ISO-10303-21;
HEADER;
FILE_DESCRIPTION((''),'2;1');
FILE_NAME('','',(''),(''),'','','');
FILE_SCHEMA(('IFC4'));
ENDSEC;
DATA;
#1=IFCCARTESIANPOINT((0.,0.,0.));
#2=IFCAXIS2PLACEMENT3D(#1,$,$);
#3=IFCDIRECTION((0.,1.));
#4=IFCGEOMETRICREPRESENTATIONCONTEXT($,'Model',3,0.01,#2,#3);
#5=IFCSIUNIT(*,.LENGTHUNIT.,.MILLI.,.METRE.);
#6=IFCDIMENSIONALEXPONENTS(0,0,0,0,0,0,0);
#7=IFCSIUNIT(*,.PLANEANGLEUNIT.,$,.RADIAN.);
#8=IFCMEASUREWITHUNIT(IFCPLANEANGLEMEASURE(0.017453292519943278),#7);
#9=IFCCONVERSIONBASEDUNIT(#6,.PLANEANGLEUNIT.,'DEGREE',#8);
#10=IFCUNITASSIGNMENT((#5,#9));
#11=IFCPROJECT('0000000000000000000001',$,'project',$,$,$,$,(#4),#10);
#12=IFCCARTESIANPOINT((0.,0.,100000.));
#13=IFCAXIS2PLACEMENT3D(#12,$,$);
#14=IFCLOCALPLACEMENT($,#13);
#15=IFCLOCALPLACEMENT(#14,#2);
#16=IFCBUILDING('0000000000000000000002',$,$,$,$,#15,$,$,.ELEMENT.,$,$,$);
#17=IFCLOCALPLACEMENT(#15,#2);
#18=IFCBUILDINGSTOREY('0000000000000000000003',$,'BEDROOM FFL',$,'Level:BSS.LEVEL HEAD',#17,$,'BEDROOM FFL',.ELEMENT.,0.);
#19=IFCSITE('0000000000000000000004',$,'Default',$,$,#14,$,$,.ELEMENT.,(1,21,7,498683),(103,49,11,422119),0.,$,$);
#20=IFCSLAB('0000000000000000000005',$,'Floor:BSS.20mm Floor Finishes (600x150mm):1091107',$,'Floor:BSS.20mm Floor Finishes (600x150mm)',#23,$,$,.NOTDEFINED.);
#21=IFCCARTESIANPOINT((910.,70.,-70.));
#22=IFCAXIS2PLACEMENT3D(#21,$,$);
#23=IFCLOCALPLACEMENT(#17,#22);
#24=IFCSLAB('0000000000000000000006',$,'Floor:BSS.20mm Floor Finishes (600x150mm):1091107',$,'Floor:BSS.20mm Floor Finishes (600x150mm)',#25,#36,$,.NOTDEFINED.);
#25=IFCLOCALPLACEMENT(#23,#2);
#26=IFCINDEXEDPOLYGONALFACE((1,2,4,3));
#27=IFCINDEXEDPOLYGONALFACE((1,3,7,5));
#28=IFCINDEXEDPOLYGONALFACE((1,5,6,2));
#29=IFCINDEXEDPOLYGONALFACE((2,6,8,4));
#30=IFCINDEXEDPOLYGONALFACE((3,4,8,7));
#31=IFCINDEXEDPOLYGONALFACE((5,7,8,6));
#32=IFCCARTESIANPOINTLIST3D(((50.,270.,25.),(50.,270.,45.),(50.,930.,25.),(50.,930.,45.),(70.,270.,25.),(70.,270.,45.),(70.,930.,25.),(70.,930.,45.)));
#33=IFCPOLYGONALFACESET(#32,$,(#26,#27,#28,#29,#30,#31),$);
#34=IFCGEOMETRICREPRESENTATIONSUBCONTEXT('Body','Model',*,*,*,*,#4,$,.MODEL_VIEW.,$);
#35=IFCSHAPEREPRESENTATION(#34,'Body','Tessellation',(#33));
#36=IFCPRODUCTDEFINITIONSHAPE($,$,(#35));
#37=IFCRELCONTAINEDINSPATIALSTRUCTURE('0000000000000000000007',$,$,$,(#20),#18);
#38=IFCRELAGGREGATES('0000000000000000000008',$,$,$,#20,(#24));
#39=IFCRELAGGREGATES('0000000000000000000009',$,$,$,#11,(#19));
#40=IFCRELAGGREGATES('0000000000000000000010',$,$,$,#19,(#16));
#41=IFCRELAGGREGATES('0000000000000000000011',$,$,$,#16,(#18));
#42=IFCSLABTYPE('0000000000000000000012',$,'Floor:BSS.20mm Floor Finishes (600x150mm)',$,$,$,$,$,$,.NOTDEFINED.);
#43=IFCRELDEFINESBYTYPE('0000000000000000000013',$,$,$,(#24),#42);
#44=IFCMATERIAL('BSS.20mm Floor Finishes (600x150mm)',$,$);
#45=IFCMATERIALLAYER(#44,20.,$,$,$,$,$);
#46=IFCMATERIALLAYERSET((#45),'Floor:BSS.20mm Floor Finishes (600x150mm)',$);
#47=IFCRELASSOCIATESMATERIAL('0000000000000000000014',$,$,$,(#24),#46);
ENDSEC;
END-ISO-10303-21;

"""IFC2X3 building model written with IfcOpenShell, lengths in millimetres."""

from ifc_helpers import new_model, entity, si_unit, converted_unit, direction, frame, frame_2d, origin, place, context, subcontext, project, spatial, rectangle, extrude, material, layer, layer_set, type_object, element, aggregate, save


model = new_model("IFC2X3")

# Units and contexts
model_context = context("Model", 3, precision=0.01, world=origin(), true_north=direction((0.0, 1.0)))
body_context = subcontext(model_context, "Body", "Model", "MODEL_VIEW")
ifc_project = project(units=[si_unit("LENGTHUNIT", "METRE", prefix="MILLI"), converted_unit("PLANEANGLEUNIT", "DEGREE", entity("IfcPlaneAngleMeasure", 0.017453292519943278), si_unit("PLANEANGLEUNIT", "RADIAN"), dimensions=[0, 0, 0, 0, 0, 0, 0])], contexts=[model_context])

# Site, building, storey
site_placement = place(None, frame((0.0, 0.0, 100000.0)))
site = spatial("IfcSite", under=ifc_project, at=site_placement, Name="Default", CompositionType="ELEMENT", RefLatitude=(1, 21, 7, 498683), RefLongitude=(103, 49, 11, 422119), RefElevation=0.0)
building_placement = place(site_placement, origin())
building = spatial("IfcBuilding", under=site, at=building_placement, CompositionType="ELEMENT")
storey_placement = place(building_placement, origin())
storey = spatial("IfcBuildingStorey", under=building, at=storey_placement, Name="BEDROOM FFL", ObjectType="Level:BSS.LEVEL HEAD", LongName="BEDROOM FFL", CompositionType="ELEMENT", Elevation=0.0)

# Slabs
slab_1_placement = place(storey_placement, frame((910.0, 70.0, -70.0)))
slab_1 = element("IfcSlab", 1, at=slab_1_placement, inside=storey, Name="Floor:BSS.20mm Floor Finishes (600x150mm):1091107", ObjectType="Floor:BSS.20mm Floor Finishes (600x150mm)", PredefinedType="NOTDEFINED")
ifc_material_1 = material(Name="BSS.20mm Floor Finishes (600x150mm)")
ifc_layer_1 = layer(ifc_material_1, 20.0)
ifc_layer_set_1 = layer_set([ifc_layer_1], Name="Floor:BSS.20mm Floor Finishes (600x150mm)")
slab_type = type_object("IfcSlabType", Name="Floor:BSS.20mm Floor Finishes (600x150mm)", PredefinedType="NOTDEFINED")
slab_2_placement = place(slab_1_placement, origin())
slab_2 = element("IfcSlab", 2, at=slab_2_placement, type_object=slab_type, material=ifc_layer_set_1, Name="Floor:BSS.20mm Floor Finishes (600x150mm):1091107", ObjectType="Floor:BSS.20mm Floor Finishes (600x150mm)", PredefinedType="NOTDEFINED", context=body_context, shape_type="SweptSolid", body=[
    extrude(rectangle(XDim=660.0, YDim=20.0, at=frame_2d((0.0, 0.0), x_axis=(0.0, -1.0))), frame((60.0, 600.0, 45.0)), (0.0, 0.0, -1.0), 20.0),
])
aggregate(slab_1, [slab_2])

save(model, "model.ifc")
